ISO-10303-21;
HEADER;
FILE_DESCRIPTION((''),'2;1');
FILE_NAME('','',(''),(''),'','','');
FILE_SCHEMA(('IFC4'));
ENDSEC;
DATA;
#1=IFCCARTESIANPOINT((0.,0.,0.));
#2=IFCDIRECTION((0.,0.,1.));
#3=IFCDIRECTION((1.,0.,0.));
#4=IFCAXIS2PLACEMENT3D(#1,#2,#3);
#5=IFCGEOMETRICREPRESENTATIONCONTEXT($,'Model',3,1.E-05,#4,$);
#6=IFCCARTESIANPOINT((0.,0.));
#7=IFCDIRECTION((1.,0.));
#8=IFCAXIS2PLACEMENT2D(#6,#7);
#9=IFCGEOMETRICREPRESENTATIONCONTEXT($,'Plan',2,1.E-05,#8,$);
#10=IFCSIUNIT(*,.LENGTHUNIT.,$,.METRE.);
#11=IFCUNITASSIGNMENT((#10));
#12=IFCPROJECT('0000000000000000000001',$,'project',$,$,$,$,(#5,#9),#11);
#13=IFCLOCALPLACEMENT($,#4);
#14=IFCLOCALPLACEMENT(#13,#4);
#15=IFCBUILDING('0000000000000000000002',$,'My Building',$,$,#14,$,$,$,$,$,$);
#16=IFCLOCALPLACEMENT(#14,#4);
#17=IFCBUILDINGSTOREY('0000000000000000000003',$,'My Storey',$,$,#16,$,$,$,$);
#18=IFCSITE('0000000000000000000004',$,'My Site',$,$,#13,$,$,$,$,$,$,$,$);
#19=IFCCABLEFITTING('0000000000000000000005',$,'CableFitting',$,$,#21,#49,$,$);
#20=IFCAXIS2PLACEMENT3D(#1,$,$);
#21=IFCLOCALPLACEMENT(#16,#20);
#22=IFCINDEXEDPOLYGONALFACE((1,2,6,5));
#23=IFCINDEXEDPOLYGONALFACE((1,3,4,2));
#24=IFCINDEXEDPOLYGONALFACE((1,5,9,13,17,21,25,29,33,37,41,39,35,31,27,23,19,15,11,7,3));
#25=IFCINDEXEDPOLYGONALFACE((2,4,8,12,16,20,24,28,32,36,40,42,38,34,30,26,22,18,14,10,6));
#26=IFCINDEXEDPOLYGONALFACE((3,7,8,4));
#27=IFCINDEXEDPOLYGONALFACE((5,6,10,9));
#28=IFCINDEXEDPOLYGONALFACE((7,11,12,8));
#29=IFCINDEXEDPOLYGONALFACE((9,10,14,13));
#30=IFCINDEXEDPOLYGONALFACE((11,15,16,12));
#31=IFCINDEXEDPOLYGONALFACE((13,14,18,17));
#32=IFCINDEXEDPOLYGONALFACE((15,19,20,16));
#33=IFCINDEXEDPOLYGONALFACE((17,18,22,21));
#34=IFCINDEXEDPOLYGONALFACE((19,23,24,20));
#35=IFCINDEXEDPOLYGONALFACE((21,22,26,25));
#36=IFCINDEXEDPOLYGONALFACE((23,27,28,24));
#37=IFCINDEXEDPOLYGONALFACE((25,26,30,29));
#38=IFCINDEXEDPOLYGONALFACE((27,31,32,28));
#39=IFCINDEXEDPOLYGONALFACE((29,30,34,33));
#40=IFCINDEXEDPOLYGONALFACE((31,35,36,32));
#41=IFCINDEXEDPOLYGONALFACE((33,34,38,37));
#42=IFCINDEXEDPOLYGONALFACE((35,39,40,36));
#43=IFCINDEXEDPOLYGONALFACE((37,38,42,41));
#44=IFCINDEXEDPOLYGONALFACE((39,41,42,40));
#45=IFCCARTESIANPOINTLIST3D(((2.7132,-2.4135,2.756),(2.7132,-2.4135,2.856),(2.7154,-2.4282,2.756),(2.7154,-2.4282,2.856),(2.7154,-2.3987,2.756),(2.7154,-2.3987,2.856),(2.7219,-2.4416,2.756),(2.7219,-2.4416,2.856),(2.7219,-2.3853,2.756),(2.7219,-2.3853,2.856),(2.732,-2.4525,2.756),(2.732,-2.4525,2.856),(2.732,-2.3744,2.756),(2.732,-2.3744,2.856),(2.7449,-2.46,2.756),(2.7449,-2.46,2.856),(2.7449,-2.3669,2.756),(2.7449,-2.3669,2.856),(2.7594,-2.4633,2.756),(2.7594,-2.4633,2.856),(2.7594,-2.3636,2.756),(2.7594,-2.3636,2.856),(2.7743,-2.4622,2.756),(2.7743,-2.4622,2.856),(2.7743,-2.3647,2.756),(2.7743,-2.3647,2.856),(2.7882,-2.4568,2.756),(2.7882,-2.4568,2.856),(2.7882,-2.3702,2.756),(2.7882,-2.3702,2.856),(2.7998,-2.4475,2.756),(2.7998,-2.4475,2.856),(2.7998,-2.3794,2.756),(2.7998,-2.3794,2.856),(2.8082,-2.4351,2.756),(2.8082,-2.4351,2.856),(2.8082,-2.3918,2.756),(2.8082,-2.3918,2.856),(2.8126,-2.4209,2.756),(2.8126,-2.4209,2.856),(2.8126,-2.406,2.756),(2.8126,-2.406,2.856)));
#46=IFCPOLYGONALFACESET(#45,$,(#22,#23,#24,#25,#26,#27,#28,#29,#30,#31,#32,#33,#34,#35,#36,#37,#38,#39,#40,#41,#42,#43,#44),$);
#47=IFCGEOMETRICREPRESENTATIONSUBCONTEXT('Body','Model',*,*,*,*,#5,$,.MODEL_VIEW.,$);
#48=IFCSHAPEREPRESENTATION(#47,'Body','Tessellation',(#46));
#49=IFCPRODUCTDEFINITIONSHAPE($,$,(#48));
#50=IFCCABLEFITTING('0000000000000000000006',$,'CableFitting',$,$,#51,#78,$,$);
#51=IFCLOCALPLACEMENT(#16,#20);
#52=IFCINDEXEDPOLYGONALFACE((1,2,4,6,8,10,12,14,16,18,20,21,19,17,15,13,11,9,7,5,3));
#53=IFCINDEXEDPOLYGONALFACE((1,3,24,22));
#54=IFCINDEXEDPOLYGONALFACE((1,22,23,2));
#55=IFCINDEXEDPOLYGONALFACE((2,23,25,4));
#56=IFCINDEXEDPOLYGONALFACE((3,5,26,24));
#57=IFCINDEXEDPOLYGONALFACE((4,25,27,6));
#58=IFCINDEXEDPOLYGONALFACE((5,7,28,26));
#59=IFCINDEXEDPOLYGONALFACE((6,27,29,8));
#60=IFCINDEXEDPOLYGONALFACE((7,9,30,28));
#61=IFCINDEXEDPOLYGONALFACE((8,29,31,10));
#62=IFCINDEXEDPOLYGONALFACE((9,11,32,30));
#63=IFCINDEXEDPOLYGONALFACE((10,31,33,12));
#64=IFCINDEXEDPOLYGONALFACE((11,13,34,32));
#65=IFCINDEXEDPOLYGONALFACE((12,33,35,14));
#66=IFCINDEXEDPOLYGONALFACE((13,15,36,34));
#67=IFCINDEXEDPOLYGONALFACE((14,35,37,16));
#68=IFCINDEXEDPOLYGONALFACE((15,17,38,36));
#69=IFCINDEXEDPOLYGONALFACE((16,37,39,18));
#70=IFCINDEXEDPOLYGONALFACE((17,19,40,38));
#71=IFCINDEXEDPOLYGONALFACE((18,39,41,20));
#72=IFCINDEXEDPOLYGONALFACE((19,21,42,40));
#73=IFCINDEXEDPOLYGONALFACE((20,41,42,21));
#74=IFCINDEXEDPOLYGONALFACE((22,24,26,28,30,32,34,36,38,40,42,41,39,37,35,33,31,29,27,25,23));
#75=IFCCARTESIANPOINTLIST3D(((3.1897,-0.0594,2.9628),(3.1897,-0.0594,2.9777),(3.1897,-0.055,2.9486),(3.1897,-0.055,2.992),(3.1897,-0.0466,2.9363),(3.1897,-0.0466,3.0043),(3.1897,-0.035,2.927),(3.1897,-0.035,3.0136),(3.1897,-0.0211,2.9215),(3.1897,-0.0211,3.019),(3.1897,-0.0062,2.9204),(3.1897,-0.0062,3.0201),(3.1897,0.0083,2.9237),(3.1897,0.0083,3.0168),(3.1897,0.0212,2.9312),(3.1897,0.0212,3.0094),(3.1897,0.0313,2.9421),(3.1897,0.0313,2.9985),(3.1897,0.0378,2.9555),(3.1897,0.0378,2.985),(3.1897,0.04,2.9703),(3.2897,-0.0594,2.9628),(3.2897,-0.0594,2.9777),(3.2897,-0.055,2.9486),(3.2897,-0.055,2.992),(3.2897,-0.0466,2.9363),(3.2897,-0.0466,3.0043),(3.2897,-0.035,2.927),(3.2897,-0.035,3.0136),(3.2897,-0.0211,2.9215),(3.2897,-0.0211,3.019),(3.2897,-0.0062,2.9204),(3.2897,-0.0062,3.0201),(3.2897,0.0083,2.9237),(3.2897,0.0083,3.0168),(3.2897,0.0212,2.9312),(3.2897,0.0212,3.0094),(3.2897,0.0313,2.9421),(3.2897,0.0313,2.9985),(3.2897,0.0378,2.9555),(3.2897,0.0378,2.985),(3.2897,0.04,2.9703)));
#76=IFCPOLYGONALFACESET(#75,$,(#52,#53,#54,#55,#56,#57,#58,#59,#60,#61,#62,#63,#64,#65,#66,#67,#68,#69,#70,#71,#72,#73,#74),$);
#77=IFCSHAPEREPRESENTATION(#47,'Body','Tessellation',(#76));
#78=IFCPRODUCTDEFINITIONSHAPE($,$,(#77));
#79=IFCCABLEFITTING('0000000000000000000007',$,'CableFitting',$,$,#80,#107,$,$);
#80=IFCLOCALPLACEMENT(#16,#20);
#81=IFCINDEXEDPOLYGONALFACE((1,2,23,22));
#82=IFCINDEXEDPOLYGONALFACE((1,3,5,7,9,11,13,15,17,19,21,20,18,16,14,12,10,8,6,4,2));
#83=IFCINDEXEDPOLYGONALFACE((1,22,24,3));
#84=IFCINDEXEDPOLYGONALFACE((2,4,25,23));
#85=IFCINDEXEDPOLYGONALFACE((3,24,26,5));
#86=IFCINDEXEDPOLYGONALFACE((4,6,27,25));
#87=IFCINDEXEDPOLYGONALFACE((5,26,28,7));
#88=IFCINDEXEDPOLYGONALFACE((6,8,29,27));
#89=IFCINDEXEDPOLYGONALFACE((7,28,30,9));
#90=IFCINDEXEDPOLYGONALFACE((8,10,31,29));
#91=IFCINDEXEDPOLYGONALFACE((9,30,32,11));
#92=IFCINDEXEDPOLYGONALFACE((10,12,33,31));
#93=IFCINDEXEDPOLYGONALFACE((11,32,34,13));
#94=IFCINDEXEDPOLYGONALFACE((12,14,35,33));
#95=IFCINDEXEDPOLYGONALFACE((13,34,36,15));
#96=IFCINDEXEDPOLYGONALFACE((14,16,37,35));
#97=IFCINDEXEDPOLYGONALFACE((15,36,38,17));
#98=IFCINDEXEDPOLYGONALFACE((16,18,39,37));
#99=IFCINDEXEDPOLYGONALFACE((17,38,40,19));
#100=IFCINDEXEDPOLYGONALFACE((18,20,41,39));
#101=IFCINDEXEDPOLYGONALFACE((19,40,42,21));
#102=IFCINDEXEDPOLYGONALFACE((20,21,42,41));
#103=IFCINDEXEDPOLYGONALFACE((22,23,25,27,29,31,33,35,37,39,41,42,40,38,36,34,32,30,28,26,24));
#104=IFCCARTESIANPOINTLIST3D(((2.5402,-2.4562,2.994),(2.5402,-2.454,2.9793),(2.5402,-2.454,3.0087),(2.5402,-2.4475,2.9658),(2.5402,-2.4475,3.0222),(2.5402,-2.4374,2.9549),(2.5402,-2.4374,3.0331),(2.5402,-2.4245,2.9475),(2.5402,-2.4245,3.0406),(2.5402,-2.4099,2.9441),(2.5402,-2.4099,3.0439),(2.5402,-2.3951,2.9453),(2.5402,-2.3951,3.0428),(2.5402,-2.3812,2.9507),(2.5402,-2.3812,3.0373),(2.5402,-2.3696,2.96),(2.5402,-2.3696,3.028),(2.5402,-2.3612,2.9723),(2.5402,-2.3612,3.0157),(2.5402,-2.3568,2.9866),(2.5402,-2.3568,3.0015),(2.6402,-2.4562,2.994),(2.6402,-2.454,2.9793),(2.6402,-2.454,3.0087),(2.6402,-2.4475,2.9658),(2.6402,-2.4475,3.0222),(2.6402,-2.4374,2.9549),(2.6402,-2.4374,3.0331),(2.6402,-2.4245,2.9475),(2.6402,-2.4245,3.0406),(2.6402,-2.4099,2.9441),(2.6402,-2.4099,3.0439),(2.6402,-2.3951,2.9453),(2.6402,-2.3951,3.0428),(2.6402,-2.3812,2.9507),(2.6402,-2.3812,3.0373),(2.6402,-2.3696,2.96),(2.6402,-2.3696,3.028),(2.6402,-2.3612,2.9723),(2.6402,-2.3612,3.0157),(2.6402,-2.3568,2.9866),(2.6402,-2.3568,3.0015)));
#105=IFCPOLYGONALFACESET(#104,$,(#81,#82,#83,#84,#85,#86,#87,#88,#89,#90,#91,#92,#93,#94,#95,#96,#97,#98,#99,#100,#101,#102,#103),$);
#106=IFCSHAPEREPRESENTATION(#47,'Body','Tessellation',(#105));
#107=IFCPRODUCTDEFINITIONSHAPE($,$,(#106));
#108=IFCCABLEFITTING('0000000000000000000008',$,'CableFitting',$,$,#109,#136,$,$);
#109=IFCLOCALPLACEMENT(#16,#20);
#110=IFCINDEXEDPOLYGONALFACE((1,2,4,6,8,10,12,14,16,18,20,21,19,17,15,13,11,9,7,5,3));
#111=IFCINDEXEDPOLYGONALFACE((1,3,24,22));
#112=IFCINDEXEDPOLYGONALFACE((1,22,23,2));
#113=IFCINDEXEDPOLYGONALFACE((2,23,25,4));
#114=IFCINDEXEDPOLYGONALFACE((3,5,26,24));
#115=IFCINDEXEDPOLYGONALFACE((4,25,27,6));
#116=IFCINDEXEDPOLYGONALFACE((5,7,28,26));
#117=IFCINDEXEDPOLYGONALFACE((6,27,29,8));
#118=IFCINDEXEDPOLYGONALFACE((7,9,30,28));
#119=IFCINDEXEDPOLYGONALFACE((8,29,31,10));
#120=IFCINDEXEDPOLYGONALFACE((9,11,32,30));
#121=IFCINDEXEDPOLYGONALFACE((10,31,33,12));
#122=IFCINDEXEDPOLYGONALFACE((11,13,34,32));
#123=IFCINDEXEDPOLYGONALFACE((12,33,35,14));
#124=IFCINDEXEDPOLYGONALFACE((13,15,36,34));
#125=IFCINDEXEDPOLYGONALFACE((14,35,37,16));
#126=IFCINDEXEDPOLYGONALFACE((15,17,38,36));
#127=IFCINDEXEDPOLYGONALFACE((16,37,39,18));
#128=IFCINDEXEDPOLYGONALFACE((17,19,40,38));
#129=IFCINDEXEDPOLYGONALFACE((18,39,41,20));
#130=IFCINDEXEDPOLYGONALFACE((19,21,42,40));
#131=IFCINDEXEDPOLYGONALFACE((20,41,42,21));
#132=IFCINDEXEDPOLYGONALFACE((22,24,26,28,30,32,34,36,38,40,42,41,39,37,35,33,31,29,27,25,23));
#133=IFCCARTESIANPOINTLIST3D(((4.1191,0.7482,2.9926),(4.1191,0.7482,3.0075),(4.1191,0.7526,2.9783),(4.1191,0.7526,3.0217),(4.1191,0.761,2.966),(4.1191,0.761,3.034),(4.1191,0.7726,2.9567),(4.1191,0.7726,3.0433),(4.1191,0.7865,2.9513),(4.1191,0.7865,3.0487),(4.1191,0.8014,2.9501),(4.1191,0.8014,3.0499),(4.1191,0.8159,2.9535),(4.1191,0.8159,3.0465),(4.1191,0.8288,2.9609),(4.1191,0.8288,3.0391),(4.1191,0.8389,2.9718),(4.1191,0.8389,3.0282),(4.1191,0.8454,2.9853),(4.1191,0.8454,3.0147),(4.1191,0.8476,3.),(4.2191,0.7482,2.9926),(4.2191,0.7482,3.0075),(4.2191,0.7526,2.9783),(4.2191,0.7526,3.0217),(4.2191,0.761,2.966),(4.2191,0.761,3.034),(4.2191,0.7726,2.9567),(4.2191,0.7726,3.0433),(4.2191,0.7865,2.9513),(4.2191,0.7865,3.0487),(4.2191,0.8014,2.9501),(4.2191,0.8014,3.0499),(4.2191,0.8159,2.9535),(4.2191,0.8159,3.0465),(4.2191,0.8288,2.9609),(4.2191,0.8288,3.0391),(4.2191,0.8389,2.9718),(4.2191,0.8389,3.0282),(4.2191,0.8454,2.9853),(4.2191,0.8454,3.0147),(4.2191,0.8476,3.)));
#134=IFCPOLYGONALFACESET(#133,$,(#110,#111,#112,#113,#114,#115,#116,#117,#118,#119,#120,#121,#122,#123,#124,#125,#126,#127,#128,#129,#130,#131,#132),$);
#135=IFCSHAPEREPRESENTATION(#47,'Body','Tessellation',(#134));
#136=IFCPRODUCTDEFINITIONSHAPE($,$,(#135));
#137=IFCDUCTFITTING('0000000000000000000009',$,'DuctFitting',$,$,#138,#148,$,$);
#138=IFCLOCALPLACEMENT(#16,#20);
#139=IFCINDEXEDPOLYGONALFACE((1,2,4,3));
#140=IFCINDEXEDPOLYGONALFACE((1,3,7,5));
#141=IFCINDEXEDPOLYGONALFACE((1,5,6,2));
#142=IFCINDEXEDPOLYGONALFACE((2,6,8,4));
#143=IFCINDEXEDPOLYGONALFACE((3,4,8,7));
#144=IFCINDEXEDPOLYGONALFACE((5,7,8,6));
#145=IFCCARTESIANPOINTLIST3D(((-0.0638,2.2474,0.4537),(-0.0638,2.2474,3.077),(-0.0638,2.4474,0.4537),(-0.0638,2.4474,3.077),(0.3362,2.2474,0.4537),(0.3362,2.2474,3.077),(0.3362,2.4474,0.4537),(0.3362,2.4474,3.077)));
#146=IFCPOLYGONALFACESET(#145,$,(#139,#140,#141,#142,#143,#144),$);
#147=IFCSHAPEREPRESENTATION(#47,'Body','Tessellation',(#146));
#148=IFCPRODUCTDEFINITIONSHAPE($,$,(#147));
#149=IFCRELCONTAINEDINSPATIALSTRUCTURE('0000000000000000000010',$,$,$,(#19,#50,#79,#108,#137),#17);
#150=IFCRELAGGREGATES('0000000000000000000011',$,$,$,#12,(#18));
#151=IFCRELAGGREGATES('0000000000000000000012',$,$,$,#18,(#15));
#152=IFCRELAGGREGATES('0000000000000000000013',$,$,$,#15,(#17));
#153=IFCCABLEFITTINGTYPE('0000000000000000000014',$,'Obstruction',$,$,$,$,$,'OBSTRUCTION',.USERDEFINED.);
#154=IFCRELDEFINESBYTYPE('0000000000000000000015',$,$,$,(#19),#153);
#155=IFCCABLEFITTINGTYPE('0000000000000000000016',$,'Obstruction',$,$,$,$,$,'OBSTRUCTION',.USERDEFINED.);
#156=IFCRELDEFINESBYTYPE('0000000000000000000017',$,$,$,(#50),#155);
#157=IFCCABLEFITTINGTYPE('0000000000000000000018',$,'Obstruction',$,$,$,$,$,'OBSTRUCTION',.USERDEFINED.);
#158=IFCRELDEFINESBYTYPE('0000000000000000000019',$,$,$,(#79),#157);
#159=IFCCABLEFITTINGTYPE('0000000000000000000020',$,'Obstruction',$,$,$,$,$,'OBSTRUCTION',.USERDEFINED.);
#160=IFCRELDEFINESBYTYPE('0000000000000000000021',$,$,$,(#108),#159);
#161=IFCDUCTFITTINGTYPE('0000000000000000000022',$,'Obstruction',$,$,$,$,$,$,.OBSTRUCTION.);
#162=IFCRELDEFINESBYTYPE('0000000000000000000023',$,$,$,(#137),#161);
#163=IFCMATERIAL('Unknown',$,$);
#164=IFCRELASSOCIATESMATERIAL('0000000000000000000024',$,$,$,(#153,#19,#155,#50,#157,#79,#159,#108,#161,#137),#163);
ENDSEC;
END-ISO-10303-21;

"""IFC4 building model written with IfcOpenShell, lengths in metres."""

from ifc_helpers import new_model, si_unit, frame, origin_with_axes, origin_2d_with_axis, place, context, subcontext, project, spatial, rectangle, circle, extrude, material, material_profile, profile_set, profile_usage, type_object, element, save


model = new_model("IFC4")

# Units and contexts
model_context = context("Model", 3, precision=1e-05, world=origin_with_axes())
plan_context = context("Plan", 2, precision=1e-05, world=origin_2d_with_axis())
body_context_1 = subcontext(model_context, "Body", "Model", "MODEL_VIEW")
ifc_project = project(units=[si_unit("LENGTHUNIT", "METRE")], contexts=[model_context, plan_context])

# Site, building, storey
site_placement = place(None, origin_with_axes())
site = spatial("IfcSite", under=ifc_project, at=site_placement, Name="My Site")
building_placement = place(site_placement, origin_with_axes())
building = spatial("IfcBuilding", under=site, at=building_placement, Name="My Building")
storey_placement = place(building_placement, origin_with_axes())
storey = spatial("IfcBuildingStorey", under=building, at=storey_placement, Name="My Storey")

# Shared definitions
ifc_material = material(Name="Unknown")

# Cable fittings
ifc_material_profile_1 = material_profile(ifc_material, circle(Radius=0.05))
ifc_profile_set_1 = profile_set([ifc_material_profile_1])
ifc_profile_usage_1 = profile_usage(ifc_profile_set_1, cardinal=5)
cable_fitting_type_1 = type_object("IfcCableFittingType", Name="Obstruction", ElementType="OBSTRUCTION", PredefinedType="USERDEFINED", material=ifc_profile_set_1)
cable_fitting_1_placement = place(storey_placement, frame((2.7632, -2.4135, 2.856), z_axis=(0.0, 0.0, -1.0), x_axis=(-1.0, 0.0, 0.0)))
element("IfcCableFitting", 1, at=cable_fitting_1_placement, inside=storey, type_object=cable_fitting_type_1, material=ifc_profile_usage_1, Name="CableFitting", context=body_context_1, shape_type="SweptSolid", body=[
    extrude(circle(Radius=0.05), origin_with_axes(), (0.0, 0.0, 1.0), 0.1),
])
ifc_material_profile_2 = material_profile(ifc_material, circle(Radius=0.05))
ifc_profile_set_2 = profile_set([ifc_material_profile_2])
ifc_profile_usage_2 = profile_usage(ifc_profile_set_2, cardinal=5)
cable_fitting_type_2 = type_object("IfcCableFittingType", Name="Obstruction", ElementType="OBSTRUCTION", PredefinedType="USERDEFINED", material=ifc_profile_set_2)
cable_fitting_2_placement = place(storey_placement, frame((3.1897, -0.01, 2.9703), z_axis=(1.0, 0.0, 0.0), x_axis=(0.0, 1.0, 0.0)))
element("IfcCableFitting", 2, at=cable_fitting_2_placement, inside=storey, type_object=cable_fitting_type_2, material=ifc_profile_usage_2, Name="CableFitting", context=body_context_1, shape_type="SweptSolid", body=[
    extrude(circle(Radius=0.05), origin_with_axes(), (0.0, 0.0, 1.0), 0.1),
])
ifc_material_profile_3 = material_profile(ifc_material, circle(Radius=0.05))
ifc_profile_set_3 = profile_set([ifc_material_profile_3])
ifc_profile_usage_3 = profile_usage(ifc_profile_set_3, cardinal=5)
cable_fitting_type_3 = type_object("IfcCableFittingType", Name="Obstruction", ElementType="OBSTRUCTION", PredefinedType="USERDEFINED", material=ifc_profile_set_3)
cable_fitting_3_placement = place(storey_placement, frame((2.6402, -2.4062, 2.994), z_axis=(-1.0, 0.0, 0.0), x_axis=(0.0, -1.0, 0.0)))
element("IfcCableFitting", 3, at=cable_fitting_3_placement, inside=storey, type_object=cable_fitting_type_3, material=ifc_profile_usage_3, Name="CableFitting", context=body_context_1, shape_type="SweptSolid", body=[
    extrude(circle(Radius=0.05), origin_with_axes(), (0.0, 0.0, 1.0), 0.1),
])
ifc_material_profile_4 = material_profile(ifc_material, circle(Radius=0.05))
ifc_profile_set_4 = profile_set([ifc_material_profile_4])
ifc_profile_usage_4 = profile_usage(ifc_profile_set_4, cardinal=5)
cable_fitting_type_4 = type_object("IfcCableFittingType", Name="Obstruction", ElementType="OBSTRUCTION", PredefinedType="USERDEFINED", material=ifc_profile_set_4)
cable_fitting_4_placement = place(storey_placement, frame((4.1191, 0.7976, 3.0), z_axis=(1.0, -0.000001, 0.000001), x_axis=(0.000001, 1.0, 0.0)))
element("IfcCableFitting", 4, at=cable_fitting_4_placement, inside=storey, type_object=cable_fitting_type_4, material=ifc_profile_usage_4, Name="CableFitting", context=body_context_1, shape_type="SweptSolid", body=[
    extrude(circle(Radius=0.05), origin_with_axes(), (0.0, 0.0, 1.0), 0.1),
])

# Duct fitting
ifc_material_profile_5 = material_profile(ifc_material, rectangle(XDim=0.4, YDim=0.2))
ifc_profile_set_5 = profile_set([ifc_material_profile_5])
ifc_profile_usage_5 = profile_usage(ifc_profile_set_5, cardinal=5)
duct_fitting_type_1 = type_object("IfcDuctFittingType", Name="Obstruction", PredefinedType="OBSTRUCTION", material=ifc_profile_set_5)
duct_fitting_1_placement = place(storey_placement, frame((0.1362, 2.3474, 3.077), z_axis=(0.0, 0.0, -1.0), x_axis=(-1.0, 0.0, 0.0)))
element("IfcDuctFitting", 5, at=duct_fitting_1_placement, inside=storey, type_object=duct_fitting_type_1, material=ifc_profile_usage_5, Name="DuctFitting", context=body_context_1, shape_type="SweptSolid", body=[
    extrude(rectangle(XDim=0.4, YDim=0.2), origin_with_axes(), (0.0, 0.0, 1.0), 2.6233),
])

save(model, "model.ifc")
